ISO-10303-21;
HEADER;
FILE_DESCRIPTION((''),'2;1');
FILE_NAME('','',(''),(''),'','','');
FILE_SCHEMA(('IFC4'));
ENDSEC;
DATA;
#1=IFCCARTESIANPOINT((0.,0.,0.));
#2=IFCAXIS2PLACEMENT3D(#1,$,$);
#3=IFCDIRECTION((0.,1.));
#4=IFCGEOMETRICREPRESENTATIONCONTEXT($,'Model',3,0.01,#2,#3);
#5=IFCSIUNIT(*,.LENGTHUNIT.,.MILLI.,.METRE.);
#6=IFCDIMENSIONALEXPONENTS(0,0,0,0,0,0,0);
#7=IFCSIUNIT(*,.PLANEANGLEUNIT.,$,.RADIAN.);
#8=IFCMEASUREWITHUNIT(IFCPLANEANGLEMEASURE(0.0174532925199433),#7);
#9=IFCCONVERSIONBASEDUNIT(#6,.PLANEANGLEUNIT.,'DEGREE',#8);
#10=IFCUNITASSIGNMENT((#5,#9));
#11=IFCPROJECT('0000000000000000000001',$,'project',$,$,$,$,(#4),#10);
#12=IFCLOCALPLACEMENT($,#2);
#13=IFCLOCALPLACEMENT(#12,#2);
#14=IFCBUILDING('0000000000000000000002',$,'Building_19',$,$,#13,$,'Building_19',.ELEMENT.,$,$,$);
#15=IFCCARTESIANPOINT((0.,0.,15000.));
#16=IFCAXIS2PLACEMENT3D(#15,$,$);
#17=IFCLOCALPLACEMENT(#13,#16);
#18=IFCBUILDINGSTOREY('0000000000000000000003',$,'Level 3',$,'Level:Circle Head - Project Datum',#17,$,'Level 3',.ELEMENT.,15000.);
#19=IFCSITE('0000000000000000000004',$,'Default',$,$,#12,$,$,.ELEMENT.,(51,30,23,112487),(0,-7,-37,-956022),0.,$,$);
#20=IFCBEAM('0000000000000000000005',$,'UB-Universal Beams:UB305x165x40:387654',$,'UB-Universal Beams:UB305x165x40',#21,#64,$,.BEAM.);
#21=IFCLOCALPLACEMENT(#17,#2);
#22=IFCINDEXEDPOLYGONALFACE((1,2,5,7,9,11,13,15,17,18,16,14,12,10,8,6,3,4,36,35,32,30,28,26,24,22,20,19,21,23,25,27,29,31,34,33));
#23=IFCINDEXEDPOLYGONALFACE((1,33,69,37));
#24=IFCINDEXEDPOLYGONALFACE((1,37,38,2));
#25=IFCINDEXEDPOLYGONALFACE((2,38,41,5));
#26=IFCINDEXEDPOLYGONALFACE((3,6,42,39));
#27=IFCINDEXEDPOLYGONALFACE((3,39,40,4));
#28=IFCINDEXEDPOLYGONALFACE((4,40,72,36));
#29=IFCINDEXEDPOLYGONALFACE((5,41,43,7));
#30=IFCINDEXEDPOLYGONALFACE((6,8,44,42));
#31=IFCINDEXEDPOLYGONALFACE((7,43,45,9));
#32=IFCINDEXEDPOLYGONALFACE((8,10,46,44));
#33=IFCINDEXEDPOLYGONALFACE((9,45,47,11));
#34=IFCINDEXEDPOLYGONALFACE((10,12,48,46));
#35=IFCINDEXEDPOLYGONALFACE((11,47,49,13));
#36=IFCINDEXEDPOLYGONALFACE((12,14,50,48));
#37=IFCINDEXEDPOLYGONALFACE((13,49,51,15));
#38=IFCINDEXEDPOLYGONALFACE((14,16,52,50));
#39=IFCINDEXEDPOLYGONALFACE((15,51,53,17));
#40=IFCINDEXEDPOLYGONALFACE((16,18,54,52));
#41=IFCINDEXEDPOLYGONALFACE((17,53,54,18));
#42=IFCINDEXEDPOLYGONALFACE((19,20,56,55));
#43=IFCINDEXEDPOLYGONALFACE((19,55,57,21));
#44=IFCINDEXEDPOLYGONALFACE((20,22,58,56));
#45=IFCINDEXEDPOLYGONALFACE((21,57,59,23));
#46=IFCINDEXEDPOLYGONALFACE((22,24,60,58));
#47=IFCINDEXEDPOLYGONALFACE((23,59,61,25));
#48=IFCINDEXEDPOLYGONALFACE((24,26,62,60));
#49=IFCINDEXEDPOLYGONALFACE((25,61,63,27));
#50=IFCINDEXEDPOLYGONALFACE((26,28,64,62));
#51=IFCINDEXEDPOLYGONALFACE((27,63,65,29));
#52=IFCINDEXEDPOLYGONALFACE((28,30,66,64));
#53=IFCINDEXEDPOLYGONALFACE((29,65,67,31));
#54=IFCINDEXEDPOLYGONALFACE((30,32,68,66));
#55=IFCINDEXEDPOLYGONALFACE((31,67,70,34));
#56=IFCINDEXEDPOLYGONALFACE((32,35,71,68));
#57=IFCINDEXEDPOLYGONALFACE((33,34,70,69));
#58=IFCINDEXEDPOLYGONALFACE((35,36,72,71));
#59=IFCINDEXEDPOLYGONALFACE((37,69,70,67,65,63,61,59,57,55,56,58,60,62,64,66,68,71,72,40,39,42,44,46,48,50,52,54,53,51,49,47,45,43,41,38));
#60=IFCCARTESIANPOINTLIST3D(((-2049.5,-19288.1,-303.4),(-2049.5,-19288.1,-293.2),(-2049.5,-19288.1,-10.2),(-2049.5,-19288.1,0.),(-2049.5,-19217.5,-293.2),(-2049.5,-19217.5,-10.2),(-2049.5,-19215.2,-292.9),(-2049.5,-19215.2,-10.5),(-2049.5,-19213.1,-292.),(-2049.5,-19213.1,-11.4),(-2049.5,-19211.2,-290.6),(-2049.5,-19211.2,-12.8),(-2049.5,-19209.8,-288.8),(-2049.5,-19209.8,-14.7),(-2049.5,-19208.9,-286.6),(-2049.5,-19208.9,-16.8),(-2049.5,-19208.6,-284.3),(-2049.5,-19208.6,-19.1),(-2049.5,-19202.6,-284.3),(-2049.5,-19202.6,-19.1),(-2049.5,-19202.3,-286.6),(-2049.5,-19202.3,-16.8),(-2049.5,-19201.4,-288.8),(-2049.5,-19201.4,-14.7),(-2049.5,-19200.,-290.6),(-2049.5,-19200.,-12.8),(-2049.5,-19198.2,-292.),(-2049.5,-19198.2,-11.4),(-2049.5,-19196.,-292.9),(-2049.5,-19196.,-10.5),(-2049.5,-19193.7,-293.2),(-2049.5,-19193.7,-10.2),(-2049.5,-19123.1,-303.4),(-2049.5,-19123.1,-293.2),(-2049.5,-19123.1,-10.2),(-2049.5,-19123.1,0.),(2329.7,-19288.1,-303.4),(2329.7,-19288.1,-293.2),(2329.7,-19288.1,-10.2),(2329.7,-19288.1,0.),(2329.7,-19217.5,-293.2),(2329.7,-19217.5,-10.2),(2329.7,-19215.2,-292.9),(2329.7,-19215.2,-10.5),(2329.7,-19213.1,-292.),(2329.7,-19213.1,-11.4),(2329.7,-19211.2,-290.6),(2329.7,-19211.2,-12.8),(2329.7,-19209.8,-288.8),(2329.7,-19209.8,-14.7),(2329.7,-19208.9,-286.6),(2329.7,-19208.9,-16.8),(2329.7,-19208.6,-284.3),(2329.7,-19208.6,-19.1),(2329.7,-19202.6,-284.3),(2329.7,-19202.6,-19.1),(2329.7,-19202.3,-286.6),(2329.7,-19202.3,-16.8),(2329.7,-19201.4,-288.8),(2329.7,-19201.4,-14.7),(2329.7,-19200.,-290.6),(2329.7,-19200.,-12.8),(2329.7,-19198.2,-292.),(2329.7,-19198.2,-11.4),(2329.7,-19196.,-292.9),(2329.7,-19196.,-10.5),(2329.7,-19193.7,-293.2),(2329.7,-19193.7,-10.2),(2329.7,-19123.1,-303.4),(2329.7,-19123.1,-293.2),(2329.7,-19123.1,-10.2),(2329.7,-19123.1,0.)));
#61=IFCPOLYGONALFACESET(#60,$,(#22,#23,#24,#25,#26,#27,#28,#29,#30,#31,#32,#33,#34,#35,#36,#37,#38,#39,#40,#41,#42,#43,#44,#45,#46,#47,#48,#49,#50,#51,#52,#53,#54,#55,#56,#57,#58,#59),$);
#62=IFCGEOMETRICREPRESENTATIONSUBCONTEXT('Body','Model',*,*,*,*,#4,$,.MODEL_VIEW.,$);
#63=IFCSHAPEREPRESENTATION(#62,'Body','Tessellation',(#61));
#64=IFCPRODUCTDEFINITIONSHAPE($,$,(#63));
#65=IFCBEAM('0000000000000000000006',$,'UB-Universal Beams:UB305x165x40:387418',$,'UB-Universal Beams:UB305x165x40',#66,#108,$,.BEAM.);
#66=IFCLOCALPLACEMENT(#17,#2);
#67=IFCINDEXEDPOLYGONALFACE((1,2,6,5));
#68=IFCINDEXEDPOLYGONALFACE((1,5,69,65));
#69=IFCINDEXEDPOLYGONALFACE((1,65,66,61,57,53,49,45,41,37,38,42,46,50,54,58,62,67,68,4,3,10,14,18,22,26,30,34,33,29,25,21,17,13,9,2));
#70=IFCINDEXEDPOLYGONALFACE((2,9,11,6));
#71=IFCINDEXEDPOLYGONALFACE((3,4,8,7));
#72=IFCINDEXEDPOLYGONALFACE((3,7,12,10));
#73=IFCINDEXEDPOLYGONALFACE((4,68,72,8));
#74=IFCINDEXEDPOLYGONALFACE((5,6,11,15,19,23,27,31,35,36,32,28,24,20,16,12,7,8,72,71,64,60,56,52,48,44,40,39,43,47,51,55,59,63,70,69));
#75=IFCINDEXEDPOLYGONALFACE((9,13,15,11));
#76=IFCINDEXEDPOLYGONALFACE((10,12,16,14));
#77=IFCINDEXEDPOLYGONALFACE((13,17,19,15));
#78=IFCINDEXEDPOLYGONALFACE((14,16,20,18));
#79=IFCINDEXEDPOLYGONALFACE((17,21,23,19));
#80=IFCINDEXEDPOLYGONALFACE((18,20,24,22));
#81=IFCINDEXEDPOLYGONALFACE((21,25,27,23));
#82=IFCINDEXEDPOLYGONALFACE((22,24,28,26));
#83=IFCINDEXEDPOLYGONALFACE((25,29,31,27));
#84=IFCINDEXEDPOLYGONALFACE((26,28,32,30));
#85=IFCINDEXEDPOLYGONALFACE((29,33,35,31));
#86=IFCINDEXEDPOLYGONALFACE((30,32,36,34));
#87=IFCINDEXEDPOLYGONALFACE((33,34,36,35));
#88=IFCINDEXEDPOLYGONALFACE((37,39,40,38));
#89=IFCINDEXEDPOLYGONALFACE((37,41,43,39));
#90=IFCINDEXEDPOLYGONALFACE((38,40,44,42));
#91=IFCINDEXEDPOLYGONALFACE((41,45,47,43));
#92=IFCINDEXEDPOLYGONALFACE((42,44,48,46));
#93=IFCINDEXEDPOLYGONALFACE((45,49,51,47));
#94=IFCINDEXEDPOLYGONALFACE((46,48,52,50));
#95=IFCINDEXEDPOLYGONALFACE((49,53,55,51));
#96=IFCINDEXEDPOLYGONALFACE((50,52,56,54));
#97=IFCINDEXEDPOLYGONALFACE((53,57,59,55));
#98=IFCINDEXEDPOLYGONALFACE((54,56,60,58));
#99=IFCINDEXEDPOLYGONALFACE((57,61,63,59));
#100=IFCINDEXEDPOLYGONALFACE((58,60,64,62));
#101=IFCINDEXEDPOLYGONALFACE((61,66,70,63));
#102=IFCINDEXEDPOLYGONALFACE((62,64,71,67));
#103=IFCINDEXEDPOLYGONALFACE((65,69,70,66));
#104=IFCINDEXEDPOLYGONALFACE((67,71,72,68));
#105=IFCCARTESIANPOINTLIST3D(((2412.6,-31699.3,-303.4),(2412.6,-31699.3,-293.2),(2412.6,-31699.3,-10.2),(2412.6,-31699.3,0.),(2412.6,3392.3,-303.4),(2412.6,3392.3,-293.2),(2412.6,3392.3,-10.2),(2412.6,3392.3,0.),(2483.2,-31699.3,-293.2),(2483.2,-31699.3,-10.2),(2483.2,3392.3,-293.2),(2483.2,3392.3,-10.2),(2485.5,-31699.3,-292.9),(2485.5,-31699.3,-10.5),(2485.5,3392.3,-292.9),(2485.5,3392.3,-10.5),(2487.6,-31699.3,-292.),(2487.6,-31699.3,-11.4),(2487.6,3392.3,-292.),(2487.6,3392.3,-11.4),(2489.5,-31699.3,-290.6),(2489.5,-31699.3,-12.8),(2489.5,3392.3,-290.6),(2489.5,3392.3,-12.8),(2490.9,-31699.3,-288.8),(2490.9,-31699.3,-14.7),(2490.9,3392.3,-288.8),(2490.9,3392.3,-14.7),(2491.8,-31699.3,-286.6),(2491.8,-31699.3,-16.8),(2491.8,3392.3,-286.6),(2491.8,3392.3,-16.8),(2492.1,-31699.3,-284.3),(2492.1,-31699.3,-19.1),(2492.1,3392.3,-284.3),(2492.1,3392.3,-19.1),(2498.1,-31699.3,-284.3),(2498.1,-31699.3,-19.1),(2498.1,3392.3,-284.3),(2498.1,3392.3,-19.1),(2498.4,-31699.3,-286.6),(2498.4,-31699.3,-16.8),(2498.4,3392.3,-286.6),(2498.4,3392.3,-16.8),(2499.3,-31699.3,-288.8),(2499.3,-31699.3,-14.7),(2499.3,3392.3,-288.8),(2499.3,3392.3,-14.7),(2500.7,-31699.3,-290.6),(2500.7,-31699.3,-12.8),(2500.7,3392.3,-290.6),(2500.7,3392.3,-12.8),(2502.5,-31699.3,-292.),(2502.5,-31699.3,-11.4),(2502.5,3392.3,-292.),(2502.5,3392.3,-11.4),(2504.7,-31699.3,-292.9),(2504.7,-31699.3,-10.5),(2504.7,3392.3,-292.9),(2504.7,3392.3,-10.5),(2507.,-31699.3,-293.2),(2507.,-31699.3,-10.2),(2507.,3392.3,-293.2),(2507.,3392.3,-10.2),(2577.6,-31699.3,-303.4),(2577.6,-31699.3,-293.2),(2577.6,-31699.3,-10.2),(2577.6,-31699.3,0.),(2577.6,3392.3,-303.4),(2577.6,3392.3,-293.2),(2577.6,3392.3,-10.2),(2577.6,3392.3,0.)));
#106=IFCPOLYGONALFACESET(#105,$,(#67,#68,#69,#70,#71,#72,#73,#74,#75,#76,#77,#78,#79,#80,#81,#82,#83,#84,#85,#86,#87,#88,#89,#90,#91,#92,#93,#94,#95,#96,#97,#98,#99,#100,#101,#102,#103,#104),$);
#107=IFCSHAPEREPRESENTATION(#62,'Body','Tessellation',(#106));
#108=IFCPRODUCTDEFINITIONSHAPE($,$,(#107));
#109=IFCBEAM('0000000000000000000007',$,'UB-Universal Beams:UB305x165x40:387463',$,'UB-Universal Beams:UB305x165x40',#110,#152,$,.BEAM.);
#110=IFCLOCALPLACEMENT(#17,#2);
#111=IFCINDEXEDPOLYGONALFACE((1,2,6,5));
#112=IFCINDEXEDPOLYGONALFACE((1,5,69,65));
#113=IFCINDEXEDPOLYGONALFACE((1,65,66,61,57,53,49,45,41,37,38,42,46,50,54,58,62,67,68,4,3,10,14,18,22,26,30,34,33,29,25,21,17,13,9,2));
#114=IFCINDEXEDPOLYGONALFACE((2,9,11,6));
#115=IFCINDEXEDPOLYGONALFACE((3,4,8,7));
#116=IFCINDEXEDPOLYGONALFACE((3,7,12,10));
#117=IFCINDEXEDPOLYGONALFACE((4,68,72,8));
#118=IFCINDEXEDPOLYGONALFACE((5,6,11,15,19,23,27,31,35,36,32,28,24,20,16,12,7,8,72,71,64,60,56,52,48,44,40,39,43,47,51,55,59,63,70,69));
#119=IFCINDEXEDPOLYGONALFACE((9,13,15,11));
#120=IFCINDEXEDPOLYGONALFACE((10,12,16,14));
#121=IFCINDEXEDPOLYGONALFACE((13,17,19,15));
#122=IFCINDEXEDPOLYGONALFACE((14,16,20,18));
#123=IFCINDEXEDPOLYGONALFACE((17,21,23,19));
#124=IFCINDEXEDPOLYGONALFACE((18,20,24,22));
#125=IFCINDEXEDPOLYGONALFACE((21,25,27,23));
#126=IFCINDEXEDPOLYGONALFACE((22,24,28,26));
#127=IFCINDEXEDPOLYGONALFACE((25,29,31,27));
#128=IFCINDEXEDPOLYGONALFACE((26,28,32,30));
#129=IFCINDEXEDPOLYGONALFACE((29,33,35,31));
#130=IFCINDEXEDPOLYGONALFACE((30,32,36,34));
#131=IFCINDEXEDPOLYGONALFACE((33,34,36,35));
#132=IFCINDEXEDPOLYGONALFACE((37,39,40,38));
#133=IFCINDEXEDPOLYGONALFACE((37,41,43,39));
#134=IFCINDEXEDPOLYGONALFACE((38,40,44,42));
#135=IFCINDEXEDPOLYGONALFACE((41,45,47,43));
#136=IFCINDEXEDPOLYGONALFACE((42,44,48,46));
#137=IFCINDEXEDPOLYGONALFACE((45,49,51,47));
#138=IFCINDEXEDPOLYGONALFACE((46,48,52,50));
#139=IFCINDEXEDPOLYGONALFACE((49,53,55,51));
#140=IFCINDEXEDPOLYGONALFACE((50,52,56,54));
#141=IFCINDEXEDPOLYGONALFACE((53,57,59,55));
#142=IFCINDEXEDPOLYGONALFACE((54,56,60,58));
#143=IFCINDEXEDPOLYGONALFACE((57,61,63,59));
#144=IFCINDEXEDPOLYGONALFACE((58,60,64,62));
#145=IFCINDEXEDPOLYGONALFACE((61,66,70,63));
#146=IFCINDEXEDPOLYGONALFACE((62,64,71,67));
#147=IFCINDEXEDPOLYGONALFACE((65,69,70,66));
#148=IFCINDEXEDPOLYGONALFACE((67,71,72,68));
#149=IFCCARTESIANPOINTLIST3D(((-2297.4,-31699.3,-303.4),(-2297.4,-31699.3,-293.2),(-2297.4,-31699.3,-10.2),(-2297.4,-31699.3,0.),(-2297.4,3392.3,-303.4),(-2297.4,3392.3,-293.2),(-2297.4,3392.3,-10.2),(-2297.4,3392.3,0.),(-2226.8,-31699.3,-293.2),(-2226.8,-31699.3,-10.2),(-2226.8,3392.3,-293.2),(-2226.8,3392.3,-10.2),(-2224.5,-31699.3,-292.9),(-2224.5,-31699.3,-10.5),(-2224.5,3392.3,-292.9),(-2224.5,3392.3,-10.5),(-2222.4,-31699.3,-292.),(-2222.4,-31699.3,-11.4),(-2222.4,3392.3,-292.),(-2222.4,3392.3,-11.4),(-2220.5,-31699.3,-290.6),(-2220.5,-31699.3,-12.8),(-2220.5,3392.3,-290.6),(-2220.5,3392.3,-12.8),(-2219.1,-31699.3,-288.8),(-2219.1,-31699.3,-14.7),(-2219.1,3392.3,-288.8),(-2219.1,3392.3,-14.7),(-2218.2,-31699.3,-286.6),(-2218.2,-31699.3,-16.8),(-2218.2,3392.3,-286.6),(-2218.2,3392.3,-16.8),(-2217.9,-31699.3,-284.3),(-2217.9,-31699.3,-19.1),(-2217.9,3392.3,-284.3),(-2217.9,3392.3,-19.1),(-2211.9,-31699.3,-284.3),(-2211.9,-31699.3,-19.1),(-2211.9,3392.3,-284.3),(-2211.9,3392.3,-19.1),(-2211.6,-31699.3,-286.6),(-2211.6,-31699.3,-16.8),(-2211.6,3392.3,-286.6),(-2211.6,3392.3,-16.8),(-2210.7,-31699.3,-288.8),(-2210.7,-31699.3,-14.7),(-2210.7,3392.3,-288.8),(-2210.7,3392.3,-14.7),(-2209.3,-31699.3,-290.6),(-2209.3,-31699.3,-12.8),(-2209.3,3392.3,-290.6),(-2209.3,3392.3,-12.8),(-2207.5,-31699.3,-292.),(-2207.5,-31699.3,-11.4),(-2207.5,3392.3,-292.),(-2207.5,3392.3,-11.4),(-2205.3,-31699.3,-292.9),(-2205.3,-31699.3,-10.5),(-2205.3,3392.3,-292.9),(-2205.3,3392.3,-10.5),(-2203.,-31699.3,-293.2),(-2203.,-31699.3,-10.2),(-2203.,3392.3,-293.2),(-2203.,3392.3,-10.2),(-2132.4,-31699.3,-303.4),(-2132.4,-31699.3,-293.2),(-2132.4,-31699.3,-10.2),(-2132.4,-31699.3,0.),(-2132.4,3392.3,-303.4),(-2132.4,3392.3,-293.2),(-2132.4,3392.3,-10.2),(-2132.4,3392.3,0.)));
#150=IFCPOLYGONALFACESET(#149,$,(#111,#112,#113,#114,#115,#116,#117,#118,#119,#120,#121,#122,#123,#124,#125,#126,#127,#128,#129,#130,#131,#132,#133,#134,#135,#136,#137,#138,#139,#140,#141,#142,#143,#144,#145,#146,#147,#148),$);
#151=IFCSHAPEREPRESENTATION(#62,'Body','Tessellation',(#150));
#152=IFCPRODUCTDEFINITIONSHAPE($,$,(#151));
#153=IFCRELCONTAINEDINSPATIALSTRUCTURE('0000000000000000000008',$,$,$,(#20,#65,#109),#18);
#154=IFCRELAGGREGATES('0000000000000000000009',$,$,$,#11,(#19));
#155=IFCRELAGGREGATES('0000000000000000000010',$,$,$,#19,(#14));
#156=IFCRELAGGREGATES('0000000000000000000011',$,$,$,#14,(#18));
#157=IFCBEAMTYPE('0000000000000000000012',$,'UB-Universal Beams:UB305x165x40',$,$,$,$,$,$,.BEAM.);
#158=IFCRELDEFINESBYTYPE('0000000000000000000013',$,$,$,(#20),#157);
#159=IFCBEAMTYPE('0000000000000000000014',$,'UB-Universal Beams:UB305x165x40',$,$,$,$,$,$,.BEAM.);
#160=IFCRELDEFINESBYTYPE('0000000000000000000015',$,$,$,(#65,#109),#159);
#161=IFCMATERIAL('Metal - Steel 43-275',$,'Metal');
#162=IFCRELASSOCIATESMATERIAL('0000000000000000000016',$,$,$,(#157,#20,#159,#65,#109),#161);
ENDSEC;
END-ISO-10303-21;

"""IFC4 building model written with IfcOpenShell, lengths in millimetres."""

from ifc_helpers import new_model, entity, si_unit, converted_unit, direction, frame, origin, place, context, subcontext, project, spatial, line, arc, indexed_curve, outline, extrude, source, transform, mapped, material, type_object, type_shapes, element, save


model = new_model("IFC4")

# Units and contexts
model_context = context("Model", 3, precision=0.01, world=origin(), true_north=direction((0.0, 1.0)))
body_context = subcontext(model_context, "Body", "Model", "MODEL_VIEW")
ifc_project = project(units=[si_unit("LENGTHUNIT", "METRE", prefix="MILLI"), converted_unit("PLANEANGLEUNIT", "DEGREE", entity("IfcPlaneAngleMeasure", 0.0174532925199433), si_unit("PLANEANGLEUNIT", "RADIAN"), dimensions=[0, 0, 0, 0, 0, 0, 0])], contexts=[model_context])

# Site, building, storey
site_placement = place(None, origin())
site = spatial("IfcSite", under=ifc_project, at=site_placement, Name="Default", CompositionType="ELEMENT", RefLatitude=(51, 30, 23, 112487), RefLongitude=(0, -7, -37, -956022), RefElevation=0.0)
building_placement = place(site_placement, origin())
building = spatial("IfcBuilding", under=site, at=building_placement, Name="Building_19", LongName="Building_19", CompositionType="ELEMENT")
storey_placement = place(building_placement, frame((0.0, 0.0, 15000.0)))
storey = spatial("IfcBuildingStorey", under=building, at=storey_placement, Name="Level 3", ObjectType="Level:Circle Head - Project Datum", LongName="Level 3", CompositionType="ELEMENT", Elevation=15000.0)

# Beams
ifc_material_1 = material(Name="Metal - Steel 43-275", Category="Metal")
beam_type_1 = type_object("IfcBeamType", Name="UB-Universal Beams:UB305x165x40", PredefinedType="BEAM", material=ifc_material_1)
shared_shape_1 = source(origin(), body_context, "Body", "SweptSolid", [
    extrude(outline(indexed_curve([(-82.5, -141.5), (-82.5, -151.7), (82.5, -151.7), (82.5, -141.5), (11.9, -141.5), (5.6, -138.9), (3.0, -132.6), (3.0, 132.6), (5.6, 138.9), (11.9, 141.5), (82.5, 141.5), (82.5, 151.7), (-82.5, 151.7), (-82.5, 141.5), (-11.9, 141.5), (-5.6, 138.9), (-3.0, 132.6), (-3.0, -132.6), (-5.6, -138.9), (-11.9, -141.5)], segments=[line(1, 2, 3, 4, 5), arc(5, 6, 7), line(7, 8), arc(8, 9, 10), line(10, 11, 12, 13, 14, 15), arc(15, 16, 17), line(17, 18), arc(18, 19, 20), line(20, 1)], self_intersect=False)), frame((-2189.6, 0.0, 0.0), z_axis=(-1.0, 0.0, 0.0), x_axis=(0.0, -1.0, 0.0)), (0.0, 0.0, -1.0), 4379.2),
])
type_shapes(beam_type_1, [shared_shape_1])
for number, where, name in (
    (1, (140.1, -19205.6, -151.7), "UB-Universal Beams:UB305x165x40:387654"),
):
    element("IfcBeam", number, at=place(storey_placement, frame(where)), inside=storey, type_object=beam_type_1, material=ifc_material_1, Name=name, ObjectType="UB-Universal Beams:UB305x165x40", PredefinedType="BEAM", context=body_context, shape_type="MappedRepresentation", body=[
        mapped(shared_shape_1, transform((0.0, 0.0, 0.0), scale=1.0)),
    ])
beam_type_2 = type_object("IfcBeamType", Name="UB-Universal Beams:UB305x165x40", PredefinedType="BEAM", material=ifc_material_1)
shared_shape_2 = source(origin(), body_context, "Body", "SweptSolid", [
    extrude(outline(indexed_curve([(-82.5, -141.5), (-82.5, -151.7), (82.5, -151.7), (82.5, -141.5), (11.9, -141.5), (5.6, -138.9), (3.0, -132.6), (3.0, 132.6), (5.6, 138.9), (11.9, 141.5), (82.5, 141.5), (82.5, 151.7), (-82.5, 151.7), (-82.5, 141.5), (-11.9, 141.5), (-5.6, 138.9), (-3.0, 132.6), (-3.0, -132.6), (-5.6, -138.9), (-11.9, -141.5)], segments=[line(1, 2, 3, 4, 5), arc(5, 6, 7), line(7, 8), arc(8, 9, 10), line(10, 11, 12, 13, 14, 15), arc(15, 16, 17), line(17, 18), arc(18, 19, 20), line(20, 1)], self_intersect=False)), frame((-17545.8, 0.0, 0.0), z_axis=(-1.0, 0.0, 0.0), x_axis=(0.0, -1.0, 0.0)), (0.0, 0.0, -1.0), 35091.6),
])
type_shapes(beam_type_2, [shared_shape_2])
for number, where, z_axis, x_axis, name in (
    (2, (2495.1, -14153.5, -151.7), (0.0, 0.0, 1.0), (0.0, -1.0, 0.0), "UB-Universal Beams:UB305x165x40:387418"),
    (3, (-2214.9, -14153.5, -151.7), (0.0, 0.0, 1.0), (0.0, 1.0, 0.0), "UB-Universal Beams:UB305x165x40:387463"),
):
    element("IfcBeam", number, at=place(storey_placement, frame(where, z_axis=z_axis, x_axis=x_axis)), inside=storey, type_object=beam_type_2, material=ifc_material_1, Name=name, ObjectType="UB-Universal Beams:UB305x165x40", PredefinedType="BEAM", context=body_context, shape_type="MappedRepresentation", body=[
        mapped(shared_shape_2, transform((0.0, 0.0, 0.0), scale=1.0)),
    ])

save(model, "model.ifc")
